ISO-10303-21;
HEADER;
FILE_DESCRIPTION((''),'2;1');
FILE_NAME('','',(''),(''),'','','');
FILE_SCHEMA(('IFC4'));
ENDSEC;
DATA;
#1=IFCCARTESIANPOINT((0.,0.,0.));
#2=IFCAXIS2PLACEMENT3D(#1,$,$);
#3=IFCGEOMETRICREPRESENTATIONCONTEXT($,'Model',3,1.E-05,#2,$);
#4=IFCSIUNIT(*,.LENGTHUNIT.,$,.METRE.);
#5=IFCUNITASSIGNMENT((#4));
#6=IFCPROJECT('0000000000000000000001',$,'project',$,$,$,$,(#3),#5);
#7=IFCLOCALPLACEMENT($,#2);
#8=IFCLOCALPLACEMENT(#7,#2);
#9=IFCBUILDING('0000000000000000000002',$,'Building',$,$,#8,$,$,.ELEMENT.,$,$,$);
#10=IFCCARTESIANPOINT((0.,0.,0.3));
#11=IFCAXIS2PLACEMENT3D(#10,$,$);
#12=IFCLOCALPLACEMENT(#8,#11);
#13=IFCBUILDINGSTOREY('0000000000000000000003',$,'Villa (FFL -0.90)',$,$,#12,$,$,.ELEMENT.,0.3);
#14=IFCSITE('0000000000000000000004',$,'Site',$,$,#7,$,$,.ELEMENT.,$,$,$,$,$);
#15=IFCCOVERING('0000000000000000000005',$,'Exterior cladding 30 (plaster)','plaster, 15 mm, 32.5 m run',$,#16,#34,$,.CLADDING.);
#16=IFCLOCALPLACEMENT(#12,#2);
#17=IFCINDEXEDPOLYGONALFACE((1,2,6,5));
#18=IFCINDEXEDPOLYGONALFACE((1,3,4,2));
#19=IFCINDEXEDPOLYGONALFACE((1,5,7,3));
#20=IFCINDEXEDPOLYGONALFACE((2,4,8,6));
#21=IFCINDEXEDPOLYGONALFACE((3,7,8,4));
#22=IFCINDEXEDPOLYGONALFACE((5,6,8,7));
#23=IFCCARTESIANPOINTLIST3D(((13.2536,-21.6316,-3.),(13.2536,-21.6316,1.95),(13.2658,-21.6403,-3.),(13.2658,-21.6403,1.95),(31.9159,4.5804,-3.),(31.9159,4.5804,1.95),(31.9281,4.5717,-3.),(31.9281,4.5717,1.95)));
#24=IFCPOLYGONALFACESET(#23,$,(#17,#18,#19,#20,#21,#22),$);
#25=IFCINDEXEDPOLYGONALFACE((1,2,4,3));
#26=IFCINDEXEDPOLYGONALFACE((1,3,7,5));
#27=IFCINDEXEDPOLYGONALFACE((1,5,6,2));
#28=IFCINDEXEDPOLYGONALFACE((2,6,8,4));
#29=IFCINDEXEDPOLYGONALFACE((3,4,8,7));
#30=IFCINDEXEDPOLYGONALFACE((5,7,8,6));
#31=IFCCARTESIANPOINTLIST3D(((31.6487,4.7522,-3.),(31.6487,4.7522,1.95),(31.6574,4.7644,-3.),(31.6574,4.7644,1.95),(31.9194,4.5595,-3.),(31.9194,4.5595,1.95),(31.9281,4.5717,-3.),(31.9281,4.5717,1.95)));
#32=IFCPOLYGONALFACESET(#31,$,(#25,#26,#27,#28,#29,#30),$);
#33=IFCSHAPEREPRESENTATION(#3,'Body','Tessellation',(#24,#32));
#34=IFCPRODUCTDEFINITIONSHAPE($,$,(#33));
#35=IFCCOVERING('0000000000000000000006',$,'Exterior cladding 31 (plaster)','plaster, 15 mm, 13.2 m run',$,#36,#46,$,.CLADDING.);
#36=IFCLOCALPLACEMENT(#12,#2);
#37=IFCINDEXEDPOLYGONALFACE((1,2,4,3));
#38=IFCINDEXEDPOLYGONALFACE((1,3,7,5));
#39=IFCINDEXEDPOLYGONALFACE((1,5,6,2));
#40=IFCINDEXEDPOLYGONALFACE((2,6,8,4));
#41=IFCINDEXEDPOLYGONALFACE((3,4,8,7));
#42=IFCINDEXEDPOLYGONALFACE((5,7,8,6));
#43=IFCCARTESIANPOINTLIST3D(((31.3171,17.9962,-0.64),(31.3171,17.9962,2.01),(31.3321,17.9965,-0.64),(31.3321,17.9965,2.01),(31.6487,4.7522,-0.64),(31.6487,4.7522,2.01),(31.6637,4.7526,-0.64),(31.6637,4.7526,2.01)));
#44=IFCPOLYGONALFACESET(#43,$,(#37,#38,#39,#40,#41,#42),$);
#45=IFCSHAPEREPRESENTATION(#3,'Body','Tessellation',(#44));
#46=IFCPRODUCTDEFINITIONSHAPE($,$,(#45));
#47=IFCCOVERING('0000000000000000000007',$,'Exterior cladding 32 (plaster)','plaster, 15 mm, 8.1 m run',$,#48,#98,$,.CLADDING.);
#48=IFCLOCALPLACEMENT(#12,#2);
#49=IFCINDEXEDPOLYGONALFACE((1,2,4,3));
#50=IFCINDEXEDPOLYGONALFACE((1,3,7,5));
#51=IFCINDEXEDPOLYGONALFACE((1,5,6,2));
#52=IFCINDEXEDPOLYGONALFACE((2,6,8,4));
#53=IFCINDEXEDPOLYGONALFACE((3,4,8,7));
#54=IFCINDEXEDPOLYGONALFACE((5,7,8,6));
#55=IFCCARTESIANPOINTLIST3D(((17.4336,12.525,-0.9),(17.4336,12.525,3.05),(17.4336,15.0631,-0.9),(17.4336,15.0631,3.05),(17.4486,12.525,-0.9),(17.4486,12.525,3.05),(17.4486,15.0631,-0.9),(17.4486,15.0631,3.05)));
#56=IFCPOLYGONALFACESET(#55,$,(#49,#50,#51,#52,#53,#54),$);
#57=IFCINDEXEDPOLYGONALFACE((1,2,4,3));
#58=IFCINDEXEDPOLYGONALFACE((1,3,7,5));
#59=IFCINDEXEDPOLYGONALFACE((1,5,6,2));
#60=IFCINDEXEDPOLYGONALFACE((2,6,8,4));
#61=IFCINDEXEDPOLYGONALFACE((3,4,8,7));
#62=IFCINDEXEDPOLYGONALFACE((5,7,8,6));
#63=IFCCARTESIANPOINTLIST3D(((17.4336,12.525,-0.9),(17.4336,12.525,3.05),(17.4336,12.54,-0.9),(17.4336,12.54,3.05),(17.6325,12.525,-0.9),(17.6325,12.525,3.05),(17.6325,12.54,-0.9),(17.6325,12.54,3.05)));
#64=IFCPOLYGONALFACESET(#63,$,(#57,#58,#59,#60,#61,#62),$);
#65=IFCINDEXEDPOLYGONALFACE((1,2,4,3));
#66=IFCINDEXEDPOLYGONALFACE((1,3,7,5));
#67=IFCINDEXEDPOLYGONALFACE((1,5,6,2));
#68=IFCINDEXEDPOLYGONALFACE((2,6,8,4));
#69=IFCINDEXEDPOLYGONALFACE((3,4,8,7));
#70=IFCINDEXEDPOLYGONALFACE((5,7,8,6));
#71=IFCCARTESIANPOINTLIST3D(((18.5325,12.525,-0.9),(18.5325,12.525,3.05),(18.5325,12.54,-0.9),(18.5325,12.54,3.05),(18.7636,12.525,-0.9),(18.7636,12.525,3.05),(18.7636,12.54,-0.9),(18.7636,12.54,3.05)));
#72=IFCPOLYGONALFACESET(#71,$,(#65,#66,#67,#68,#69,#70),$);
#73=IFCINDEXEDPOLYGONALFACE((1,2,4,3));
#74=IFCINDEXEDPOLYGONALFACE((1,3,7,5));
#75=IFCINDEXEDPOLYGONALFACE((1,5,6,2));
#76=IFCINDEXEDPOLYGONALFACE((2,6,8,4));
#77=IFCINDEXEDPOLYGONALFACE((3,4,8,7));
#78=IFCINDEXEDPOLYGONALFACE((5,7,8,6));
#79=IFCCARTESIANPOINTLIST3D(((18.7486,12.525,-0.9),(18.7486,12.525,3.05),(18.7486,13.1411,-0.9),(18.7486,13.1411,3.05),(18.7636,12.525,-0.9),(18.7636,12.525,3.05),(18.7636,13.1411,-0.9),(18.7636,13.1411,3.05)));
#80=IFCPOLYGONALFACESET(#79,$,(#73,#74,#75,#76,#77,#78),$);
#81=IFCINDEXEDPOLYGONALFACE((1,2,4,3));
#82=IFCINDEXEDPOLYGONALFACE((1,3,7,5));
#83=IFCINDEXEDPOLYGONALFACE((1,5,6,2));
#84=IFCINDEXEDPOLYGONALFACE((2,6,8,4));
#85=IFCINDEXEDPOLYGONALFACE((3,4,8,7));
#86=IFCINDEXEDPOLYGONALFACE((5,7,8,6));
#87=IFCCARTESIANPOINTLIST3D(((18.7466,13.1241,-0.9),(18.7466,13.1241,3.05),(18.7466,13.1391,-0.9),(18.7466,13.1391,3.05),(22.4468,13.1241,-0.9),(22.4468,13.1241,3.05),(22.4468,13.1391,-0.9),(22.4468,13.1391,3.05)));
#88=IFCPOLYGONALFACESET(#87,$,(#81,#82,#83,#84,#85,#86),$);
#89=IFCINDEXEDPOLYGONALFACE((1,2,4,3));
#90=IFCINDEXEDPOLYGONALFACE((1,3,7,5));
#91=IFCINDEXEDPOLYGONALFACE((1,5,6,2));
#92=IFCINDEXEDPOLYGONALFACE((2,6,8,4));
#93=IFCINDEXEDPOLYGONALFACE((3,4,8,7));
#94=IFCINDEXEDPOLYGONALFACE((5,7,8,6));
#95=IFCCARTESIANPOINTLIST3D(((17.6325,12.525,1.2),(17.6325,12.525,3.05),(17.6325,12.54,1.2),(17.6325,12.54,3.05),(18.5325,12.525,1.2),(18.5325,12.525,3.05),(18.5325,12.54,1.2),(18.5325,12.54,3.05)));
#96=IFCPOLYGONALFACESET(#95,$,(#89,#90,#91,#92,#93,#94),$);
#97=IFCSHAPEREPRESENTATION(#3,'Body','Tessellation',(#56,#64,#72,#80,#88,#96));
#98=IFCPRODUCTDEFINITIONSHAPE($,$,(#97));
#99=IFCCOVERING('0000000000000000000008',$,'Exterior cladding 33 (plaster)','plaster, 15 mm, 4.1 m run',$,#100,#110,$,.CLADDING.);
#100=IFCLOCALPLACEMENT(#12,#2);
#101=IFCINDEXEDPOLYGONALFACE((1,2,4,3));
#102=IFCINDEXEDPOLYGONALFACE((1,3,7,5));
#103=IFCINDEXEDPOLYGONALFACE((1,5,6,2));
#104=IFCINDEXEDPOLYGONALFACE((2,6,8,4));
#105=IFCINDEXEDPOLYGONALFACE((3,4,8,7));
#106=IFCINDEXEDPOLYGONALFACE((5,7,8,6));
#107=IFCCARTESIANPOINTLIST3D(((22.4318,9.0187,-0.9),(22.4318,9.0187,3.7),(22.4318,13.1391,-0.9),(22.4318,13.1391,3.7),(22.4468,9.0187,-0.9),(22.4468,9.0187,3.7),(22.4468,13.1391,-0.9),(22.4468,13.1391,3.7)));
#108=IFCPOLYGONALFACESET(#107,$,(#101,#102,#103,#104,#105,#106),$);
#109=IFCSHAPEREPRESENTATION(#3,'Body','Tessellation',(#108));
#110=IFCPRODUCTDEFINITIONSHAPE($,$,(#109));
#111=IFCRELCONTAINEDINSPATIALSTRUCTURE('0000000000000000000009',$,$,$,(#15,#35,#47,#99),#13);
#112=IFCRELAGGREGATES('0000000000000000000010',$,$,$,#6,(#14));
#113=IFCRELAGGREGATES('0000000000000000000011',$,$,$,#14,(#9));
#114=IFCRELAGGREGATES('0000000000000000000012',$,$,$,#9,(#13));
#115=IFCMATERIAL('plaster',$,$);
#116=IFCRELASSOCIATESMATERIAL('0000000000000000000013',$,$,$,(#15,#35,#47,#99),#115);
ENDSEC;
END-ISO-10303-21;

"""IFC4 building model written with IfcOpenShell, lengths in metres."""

from ifc_helpers import new_model, si_unit, frame, origin, origin_with_axes, place, context, project, spatial, polyline, outline, extrude, material, element, save


model = new_model("IFC4")

# Units and contexts
model_context = context("Model", 3, precision=1e-05, world=origin())
ifc_project = project(units=[si_unit("LENGTHUNIT", "METRE")], contexts=[model_context])

# Site, building, storey
site_placement = place(None, origin())
site = spatial("IfcSite", under=ifc_project, at=site_placement, Name="Site", CompositionType="ELEMENT")
building_placement = place(site_placement, origin())
building = spatial("IfcBuilding", under=site, at=building_placement, Name="Building", CompositionType="ELEMENT")
storey_placement = place(building_placement, frame((0.0, 0.0, 0.3)))
storey = spatial("IfcBuildingStorey", under=building, at=storey_placement, Name="Villa (FFL -0.90)", CompositionType="ELEMENT", Elevation=0.3)

# Coverings
ifc_material = material(Name="plaster")
covering_1_placement = place(storey_placement, origin_with_axes())
element("IfcCovering", 1, at=covering_1_placement, inside=storey, material=ifc_material, Name="Exterior cladding 30 (plaster)", Description="plaster, 15 mm, 32.5 m run", PredefinedType="CLADDING", context=model_context, shape_type="SweptSolid", body=[
    extrude(outline(polyline([(13.2658, -21.6403), (31.9281, 4.5717), (31.9159, 4.5804), (13.2536, -21.6316), (13.2658, -21.6403)])), frame((0.0, 0.0, -3.0)), (0.0, 0.0, 1.0), 4.95),
    extrude(outline(polyline([(31.9281, 4.5717), (31.6574, 4.7644), (31.6487, 4.7522), (31.9194, 4.5595), (31.9281, 4.5717)])), frame((0.0, 0.0, -3.0)), (0.0, 0.0, 1.0), 4.95),
])
covering_2_placement = place(storey_placement, origin_with_axes())
element("IfcCovering", 2, at=covering_2_placement, inside=storey, material=ifc_material, Name="Exterior cladding 31 (plaster)", Description="plaster, 15 mm, 13.2 m run", PredefinedType="CLADDING", context=model_context, shape_type="SweptSolid", body=[
    extrude(outline(polyline([(31.6637, 4.7526), (31.3321, 17.9965), (31.3171, 17.9962), (31.6487, 4.7522), (31.6637, 4.7526)])), frame((0.0, 0.0, -0.64)), (0.0, 0.0, 1.0), 2.65),
])
covering_3_placement = place(storey_placement, origin_with_axes())
element("IfcCovering", 3, at=covering_3_placement, inside=storey, material=ifc_material, Name="Exterior cladding 32 (plaster)", Description="plaster, 15 mm, 8.1 m run", PredefinedType="CLADDING", context=model_context, shape_type="SweptSolid", body=[
    extrude(outline(polyline([(17.4336, 15.0631), (17.4336, 12.525), (17.4486, 12.525), (17.4486, 15.0631), (17.4336, 15.0631)])), frame((0.0, 0.0, -0.9)), (0.0, 0.0, 1.0), 3.95),
    extrude(outline(polyline([(17.4336, 12.525), (17.6325, 12.525), (17.6325, 12.54), (17.4336, 12.54), (17.4336, 12.525)])), frame((0.0, 0.0, -0.9)), (0.0, 0.0, 1.0), 3.95),
    extrude(outline(polyline([(18.5325, 12.525), (18.7636, 12.525), (18.7636, 12.54), (18.5325, 12.54), (18.5325, 12.525)])), frame((0.0, 0.0, -0.9)), (0.0, 0.0, 1.0), 3.95),
    extrude(outline(polyline([(18.7636, 12.525), (18.7636, 13.1411), (18.7486, 13.1411), (18.7486, 12.525), (18.7636, 12.525)])), frame((0.0, 0.0, -0.9)), (0.0, 0.0, 1.0), 3.95),
    extrude(outline(polyline([(18.7466, 13.1241), (22.4468, 13.1241), (22.4468, 13.1391), (18.7466, 13.1391), (18.7466, 13.1241)])), frame((0.0, 0.0, -0.9)), (0.0, 0.0, 1.0), 3.95),
    extrude(outline(polyline([(17.6325, 12.525), (18.5325, 12.525), (18.5325, 12.54), (17.6325, 12.54), (17.6325, 12.525)])), frame((0.0, 0.0, 1.2)), (0.0, 0.0, 1.0), 1.85),
])
covering_4_placement = place(storey_placement, origin_with_axes())
element("IfcCovering", 4, at=covering_4_placement, inside=storey, material=ifc_material, Name="Exterior cladding 33 (plaster)", Description="plaster, 15 mm, 4.1 m run", PredefinedType="CLADDING", context=model_context, shape_type="SweptSolid", body=[
    extrude(outline(polyline([(22.4318, 13.1391), (22.4318, 9.0187), (22.4468, 9.0187), (22.4468, 13.1391), (22.4318, 13.1391)])), frame((0.0, 0.0, -0.9)), (0.0, 0.0, 1.0), 4.6),
])

save(model, "model.ifc")
